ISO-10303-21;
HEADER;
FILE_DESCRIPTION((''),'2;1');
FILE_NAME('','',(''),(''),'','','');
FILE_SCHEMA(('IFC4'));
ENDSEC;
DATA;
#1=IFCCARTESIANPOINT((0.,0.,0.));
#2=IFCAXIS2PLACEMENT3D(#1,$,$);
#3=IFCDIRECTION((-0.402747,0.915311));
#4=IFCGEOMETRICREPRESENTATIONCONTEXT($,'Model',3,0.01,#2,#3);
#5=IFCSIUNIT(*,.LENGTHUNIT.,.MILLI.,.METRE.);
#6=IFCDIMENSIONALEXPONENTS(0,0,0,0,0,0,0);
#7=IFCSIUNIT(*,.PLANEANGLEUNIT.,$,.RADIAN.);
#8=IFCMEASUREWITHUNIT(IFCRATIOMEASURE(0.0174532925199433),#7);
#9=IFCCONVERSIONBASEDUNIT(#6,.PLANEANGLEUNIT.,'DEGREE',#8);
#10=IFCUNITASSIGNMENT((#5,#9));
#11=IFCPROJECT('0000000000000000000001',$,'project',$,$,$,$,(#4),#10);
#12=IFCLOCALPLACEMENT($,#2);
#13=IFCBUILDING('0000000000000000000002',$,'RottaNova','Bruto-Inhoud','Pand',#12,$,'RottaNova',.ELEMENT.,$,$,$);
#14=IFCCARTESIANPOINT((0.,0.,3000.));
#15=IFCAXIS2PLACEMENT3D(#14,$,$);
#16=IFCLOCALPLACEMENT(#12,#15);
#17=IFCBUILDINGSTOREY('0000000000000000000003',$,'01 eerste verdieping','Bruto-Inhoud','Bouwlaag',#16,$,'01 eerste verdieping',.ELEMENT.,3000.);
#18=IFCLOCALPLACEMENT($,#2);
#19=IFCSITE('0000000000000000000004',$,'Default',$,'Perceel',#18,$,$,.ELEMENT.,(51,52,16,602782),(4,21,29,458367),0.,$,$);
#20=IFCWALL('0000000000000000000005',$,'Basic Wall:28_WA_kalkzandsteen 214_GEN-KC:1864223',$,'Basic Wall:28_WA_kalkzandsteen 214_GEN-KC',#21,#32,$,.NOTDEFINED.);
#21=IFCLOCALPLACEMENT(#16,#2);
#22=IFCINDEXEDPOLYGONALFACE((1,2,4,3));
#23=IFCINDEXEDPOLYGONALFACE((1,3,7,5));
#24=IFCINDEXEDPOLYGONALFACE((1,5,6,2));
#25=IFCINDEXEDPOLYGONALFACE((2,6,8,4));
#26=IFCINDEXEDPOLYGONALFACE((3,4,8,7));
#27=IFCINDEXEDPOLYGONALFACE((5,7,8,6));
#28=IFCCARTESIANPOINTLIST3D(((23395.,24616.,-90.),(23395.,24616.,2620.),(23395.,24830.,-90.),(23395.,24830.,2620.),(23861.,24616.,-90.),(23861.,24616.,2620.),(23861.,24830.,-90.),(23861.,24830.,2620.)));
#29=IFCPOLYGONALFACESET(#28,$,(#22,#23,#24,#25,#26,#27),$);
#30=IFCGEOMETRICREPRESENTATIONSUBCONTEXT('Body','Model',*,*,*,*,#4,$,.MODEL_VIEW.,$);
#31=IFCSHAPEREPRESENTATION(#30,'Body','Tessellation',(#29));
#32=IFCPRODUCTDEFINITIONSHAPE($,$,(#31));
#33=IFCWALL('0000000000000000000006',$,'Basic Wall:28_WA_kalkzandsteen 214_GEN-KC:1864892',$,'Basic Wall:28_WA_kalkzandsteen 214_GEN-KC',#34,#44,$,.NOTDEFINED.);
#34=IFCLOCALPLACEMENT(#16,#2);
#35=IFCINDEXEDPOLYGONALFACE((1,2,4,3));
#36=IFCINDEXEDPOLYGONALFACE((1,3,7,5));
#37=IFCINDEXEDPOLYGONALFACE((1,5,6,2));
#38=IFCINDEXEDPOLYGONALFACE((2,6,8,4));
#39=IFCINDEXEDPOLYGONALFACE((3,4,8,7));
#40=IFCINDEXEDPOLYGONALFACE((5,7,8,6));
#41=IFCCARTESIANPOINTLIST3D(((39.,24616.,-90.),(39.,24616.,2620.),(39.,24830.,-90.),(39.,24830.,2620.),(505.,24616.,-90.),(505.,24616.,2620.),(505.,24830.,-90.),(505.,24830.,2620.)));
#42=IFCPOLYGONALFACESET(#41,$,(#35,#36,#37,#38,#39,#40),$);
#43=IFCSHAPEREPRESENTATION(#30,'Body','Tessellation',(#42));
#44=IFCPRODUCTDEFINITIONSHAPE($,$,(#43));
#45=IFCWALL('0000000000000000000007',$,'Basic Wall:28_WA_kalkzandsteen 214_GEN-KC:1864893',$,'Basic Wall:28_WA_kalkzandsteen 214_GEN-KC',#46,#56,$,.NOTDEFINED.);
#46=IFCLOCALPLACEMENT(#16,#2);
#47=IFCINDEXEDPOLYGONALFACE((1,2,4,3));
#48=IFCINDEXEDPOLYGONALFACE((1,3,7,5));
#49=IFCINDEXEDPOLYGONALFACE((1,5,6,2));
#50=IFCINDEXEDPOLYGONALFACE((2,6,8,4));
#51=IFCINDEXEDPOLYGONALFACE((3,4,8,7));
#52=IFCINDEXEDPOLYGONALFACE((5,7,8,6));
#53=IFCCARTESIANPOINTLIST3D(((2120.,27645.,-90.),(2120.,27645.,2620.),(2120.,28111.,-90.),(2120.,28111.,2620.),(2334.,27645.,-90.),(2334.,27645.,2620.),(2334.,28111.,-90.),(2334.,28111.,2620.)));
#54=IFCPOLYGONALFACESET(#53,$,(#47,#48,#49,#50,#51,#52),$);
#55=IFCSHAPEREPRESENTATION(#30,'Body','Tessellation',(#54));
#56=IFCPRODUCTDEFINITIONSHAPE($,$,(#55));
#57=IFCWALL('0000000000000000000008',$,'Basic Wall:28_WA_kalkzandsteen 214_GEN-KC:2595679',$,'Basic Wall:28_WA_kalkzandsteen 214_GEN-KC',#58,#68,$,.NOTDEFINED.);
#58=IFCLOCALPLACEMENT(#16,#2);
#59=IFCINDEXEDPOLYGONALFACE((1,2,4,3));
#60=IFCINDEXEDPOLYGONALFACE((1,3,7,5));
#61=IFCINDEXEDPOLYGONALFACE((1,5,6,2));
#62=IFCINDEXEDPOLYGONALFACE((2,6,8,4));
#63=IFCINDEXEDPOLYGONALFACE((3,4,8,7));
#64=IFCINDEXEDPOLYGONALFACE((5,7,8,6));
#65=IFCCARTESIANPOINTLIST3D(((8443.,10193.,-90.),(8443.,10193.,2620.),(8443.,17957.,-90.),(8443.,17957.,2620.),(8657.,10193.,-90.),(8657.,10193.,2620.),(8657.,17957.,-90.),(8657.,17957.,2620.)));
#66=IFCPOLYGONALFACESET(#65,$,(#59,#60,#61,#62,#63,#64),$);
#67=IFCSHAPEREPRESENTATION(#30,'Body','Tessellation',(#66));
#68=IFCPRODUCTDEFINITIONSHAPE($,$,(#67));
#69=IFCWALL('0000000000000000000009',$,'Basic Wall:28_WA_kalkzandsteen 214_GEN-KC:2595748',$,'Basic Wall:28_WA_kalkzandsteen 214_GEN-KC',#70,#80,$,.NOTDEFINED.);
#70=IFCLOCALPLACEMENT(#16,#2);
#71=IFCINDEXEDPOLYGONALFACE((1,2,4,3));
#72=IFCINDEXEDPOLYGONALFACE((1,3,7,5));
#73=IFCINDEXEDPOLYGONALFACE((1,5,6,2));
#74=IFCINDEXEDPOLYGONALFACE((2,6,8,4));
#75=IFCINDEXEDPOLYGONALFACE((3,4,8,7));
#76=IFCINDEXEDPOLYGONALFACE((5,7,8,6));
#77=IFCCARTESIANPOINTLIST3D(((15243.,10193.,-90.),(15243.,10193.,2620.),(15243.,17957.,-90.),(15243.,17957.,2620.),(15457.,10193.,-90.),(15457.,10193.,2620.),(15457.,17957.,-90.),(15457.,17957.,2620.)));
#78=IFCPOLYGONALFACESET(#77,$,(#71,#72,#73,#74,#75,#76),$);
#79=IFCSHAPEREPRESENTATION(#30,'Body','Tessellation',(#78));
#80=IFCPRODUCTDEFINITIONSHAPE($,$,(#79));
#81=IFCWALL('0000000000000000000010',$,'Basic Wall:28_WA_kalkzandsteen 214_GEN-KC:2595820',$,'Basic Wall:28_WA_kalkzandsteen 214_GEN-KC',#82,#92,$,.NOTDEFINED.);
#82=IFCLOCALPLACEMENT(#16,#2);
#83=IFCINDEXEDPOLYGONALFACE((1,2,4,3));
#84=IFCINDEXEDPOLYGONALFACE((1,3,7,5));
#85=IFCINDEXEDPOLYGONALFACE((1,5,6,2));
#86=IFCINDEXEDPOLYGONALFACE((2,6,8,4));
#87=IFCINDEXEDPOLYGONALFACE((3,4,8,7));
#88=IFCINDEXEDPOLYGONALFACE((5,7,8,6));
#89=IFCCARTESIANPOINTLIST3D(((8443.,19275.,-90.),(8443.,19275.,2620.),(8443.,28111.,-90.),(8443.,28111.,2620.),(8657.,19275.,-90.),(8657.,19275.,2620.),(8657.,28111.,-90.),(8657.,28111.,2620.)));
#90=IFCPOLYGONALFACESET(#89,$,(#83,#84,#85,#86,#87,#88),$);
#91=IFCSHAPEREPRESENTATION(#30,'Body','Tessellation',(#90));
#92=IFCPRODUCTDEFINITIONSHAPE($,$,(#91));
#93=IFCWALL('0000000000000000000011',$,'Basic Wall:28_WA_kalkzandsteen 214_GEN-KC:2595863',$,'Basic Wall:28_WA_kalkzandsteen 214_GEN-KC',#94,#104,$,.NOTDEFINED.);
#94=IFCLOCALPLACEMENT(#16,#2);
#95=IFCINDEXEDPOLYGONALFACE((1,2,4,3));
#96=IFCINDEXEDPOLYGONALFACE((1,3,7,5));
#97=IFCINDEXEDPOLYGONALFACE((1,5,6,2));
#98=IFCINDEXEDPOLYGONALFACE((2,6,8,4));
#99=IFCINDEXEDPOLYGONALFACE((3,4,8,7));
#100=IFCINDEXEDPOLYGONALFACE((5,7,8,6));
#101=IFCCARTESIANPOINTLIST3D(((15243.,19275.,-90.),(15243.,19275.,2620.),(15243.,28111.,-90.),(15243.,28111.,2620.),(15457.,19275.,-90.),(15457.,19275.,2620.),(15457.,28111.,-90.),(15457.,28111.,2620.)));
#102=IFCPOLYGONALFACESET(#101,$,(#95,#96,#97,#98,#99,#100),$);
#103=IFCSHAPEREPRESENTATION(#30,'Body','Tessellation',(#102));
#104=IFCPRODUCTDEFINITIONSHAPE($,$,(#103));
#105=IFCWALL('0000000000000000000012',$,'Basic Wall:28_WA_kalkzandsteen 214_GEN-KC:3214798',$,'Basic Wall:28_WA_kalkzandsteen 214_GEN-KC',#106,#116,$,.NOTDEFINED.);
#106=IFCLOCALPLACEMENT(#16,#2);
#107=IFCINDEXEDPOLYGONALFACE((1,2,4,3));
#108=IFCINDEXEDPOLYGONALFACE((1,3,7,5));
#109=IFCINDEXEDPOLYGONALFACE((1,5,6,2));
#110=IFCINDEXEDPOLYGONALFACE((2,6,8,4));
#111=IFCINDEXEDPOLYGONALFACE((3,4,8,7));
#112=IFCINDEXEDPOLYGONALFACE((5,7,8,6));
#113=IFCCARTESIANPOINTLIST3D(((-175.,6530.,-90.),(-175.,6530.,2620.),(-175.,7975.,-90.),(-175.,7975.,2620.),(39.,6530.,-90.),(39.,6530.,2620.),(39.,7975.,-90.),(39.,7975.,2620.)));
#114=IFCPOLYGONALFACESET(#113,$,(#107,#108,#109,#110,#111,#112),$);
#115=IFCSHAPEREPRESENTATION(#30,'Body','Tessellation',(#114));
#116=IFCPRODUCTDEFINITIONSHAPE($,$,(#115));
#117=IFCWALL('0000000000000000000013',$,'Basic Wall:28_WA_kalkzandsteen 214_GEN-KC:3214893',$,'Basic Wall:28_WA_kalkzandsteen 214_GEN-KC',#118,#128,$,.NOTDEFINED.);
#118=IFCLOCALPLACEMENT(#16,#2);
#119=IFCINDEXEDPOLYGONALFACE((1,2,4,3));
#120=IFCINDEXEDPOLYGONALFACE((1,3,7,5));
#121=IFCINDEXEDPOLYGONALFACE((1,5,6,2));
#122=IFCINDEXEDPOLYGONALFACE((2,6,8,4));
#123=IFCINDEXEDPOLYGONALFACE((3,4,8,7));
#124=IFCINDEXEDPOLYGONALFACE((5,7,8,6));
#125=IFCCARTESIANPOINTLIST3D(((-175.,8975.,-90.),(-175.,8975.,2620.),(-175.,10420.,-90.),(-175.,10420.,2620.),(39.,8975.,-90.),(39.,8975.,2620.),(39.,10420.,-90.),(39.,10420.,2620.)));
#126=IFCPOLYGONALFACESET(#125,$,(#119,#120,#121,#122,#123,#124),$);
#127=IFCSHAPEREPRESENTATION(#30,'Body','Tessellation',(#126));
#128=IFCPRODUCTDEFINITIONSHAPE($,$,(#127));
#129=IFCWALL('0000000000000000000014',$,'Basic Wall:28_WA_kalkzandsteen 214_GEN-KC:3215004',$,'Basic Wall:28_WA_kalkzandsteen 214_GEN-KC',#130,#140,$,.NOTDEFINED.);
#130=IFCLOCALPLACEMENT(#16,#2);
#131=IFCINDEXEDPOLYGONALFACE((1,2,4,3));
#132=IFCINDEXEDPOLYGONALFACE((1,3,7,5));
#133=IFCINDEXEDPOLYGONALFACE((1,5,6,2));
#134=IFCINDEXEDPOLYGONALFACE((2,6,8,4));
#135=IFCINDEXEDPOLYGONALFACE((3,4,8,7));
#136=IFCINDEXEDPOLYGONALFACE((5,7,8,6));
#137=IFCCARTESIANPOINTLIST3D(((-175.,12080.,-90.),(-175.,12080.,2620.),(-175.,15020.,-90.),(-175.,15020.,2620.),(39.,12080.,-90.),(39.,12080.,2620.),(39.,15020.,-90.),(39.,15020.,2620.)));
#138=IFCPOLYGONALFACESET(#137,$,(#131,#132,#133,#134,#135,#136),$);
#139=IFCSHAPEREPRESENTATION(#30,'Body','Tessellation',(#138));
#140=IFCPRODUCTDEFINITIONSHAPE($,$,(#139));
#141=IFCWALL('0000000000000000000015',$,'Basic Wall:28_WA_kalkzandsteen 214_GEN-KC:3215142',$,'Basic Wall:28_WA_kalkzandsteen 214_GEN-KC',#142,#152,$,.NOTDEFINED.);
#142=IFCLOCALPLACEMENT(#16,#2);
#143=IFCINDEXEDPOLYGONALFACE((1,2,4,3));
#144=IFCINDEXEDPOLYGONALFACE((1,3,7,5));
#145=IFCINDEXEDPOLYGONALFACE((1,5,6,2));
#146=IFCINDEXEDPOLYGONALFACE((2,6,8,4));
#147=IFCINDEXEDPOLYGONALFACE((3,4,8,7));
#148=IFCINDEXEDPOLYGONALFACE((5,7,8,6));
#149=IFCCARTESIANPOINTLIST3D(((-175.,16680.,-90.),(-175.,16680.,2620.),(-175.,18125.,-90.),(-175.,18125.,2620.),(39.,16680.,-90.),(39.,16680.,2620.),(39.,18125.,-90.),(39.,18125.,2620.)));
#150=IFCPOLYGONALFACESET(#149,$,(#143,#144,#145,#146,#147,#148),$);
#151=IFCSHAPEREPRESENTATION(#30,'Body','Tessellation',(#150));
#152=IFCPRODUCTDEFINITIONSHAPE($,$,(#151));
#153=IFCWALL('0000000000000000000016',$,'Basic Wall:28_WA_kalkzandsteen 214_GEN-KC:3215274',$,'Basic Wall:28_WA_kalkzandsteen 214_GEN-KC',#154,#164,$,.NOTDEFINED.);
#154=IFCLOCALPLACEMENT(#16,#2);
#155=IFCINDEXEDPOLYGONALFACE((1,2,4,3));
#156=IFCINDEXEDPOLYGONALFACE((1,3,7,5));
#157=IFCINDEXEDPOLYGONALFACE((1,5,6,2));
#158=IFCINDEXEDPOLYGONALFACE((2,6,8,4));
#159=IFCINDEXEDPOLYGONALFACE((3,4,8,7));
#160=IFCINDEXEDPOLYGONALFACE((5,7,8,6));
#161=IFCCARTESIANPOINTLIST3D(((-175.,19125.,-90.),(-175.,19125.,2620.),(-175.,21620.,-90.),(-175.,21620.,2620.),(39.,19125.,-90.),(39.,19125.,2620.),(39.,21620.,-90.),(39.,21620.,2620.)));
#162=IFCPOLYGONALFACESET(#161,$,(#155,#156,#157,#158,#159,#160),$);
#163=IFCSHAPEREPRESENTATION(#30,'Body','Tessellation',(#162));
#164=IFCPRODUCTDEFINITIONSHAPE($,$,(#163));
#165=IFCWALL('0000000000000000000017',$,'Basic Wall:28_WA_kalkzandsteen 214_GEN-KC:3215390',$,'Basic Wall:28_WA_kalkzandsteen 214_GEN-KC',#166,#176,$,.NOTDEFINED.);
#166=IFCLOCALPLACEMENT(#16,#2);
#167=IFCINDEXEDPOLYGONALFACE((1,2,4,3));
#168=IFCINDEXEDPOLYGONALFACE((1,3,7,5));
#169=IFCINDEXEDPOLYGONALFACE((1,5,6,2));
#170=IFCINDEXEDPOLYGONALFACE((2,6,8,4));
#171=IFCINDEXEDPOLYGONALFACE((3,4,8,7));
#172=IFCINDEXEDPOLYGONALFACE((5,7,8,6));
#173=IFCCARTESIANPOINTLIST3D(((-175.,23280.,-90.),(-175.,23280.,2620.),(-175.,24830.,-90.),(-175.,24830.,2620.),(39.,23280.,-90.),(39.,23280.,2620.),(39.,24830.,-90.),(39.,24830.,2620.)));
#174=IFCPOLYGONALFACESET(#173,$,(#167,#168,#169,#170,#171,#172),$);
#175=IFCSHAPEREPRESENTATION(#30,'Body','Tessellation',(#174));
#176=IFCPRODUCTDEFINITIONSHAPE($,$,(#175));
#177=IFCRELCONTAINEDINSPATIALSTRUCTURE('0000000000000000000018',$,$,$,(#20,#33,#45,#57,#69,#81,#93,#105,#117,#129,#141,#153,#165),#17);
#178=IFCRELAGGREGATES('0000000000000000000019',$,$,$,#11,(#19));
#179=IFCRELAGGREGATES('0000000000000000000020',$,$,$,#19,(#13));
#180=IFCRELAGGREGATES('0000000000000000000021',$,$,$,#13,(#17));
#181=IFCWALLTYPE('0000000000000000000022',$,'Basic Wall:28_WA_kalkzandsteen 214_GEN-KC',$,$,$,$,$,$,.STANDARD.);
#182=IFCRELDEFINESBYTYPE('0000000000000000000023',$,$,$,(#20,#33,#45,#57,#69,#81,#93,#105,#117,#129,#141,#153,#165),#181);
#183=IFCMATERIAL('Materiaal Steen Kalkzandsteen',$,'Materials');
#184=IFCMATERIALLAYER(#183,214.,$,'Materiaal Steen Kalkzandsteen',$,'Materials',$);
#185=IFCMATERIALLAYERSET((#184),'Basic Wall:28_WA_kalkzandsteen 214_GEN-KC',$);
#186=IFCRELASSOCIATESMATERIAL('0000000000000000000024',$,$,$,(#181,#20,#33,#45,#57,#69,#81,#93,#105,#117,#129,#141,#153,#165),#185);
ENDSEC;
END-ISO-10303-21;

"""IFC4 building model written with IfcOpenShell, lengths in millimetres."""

from ifc_helpers import new_model, entity, si_unit, converted_unit, direction, frame, frame_2d, origin, place, context, subcontext, project, spatial, rectangle, extrude, material, layer, layer_set, type_object, element, save


model = new_model("IFC4")

# Units and contexts
model_context = context("Model", 3, precision=0.01, world=origin(), true_north=direction((-0.402747, 0.915311)))
body_context = subcontext(model_context, "Body", "Model", "MODEL_VIEW")
ifc_project = project(units=[si_unit("LENGTHUNIT", "METRE", prefix="MILLI"), converted_unit("PLANEANGLEUNIT", "DEGREE", entity("IfcRatioMeasure", 0.0174532925199433), si_unit("PLANEANGLEUNIT", "RADIAN"), dimensions=[0, 0, 0, 0, 0, 0, 0])], contexts=[model_context])

# Site, building, storey
site_placement = place(None, origin())
site = spatial("IfcSite", under=ifc_project, at=site_placement, Name="Default", ObjectType="Perceel", CompositionType="ELEMENT", RefLatitude=(51, 52, 16, 602782), RefLongitude=(4, 21, 29, 458367), RefElevation=0.0)
building_placement = place(None, origin())
building = spatial("IfcBuilding", under=site, at=building_placement, Name="RottaNova", Description="Bruto-Inhoud", ObjectType="Pand", LongName="RottaNova", CompositionType="ELEMENT")
storey_placement = place(building_placement, frame((0.0, 0.0, 3000.0)))
storey = spatial("IfcBuildingStorey", under=building, at=storey_placement, Name="01 eerste verdieping", Description="Bruto-Inhoud", ObjectType="Bouwlaag", LongName="01 eerste verdieping", CompositionType="ELEMENT", Elevation=3000.0)

# Walls
ifc_material_1 = material(Name="Materiaal Steen Kalkzandsteen", Category="Materials")
ifc_layer_1 = layer(ifc_material_1, 214.0, Name="Materiaal Steen Kalkzandsteen", Category="Materials")
ifc_layer_set_1 = layer_set([ifc_layer_1], Name="Basic Wall:28_WA_kalkzandsteen 214_GEN-KC")
wall_type_1 = type_object("IfcWallType", Name="Basic Wall:28_WA_kalkzandsteen 214_GEN-KC", PredefinedType="STANDARD", material=ifc_layer_set_1)
wall_1_placement = place(storey_placement, frame((23395.0, 24723.0, -90.0)))
element("IfcWall", 1, at=wall_1_placement, inside=storey, type_object=wall_type_1, material=ifc_layer_set_1, Name="Basic Wall:28_WA_kalkzandsteen 214_GEN-KC:1864223", ObjectType="Basic Wall:28_WA_kalkzandsteen 214_GEN-KC", PredefinedType="NOTDEFINED", context=body_context, shape_type="SweptSolid", body=[
    extrude(rectangle(XDim=466.0, YDim=214.0, at=frame_2d((233.0, 0.0), x_axis=(-1.0, 0.0))), origin(), (0.0, 0.0, 1.0), 2710.0),
])
wall_2_placement = place(storey_placement, frame((39.0, 24723.0, -90.0)))
element("IfcWall", 2, at=wall_2_placement, inside=storey, type_object=wall_type_1, material=ifc_layer_set_1, Name="Basic Wall:28_WA_kalkzandsteen 214_GEN-KC:1864892", ObjectType="Basic Wall:28_WA_kalkzandsteen 214_GEN-KC", PredefinedType="NOTDEFINED", context=body_context, shape_type="SweptSolid", body=[
    extrude(rectangle(XDim=466.0, YDim=214.0, at=frame_2d((233.0, 0.0), x_axis=(-1.0, 0.0))), origin(), (0.0, 0.0, 1.0), 2710.0),
])
wall_3_placement = place(storey_placement, frame((2227.0, 28111.0, -90.0), z_axis=(0.0, 0.0, 1.0), x_axis=(0.0, -1.0, 0.0)))
element("IfcWall", 3, at=wall_3_placement, inside=storey, type_object=wall_type_1, material=ifc_layer_set_1, Name="Basic Wall:28_WA_kalkzandsteen 214_GEN-KC:1864893", ObjectType="Basic Wall:28_WA_kalkzandsteen 214_GEN-KC", PredefinedType="NOTDEFINED", context=body_context, shape_type="SweptSolid", body=[
    extrude(rectangle(XDim=466.0, YDim=214.0, at=frame_2d((233.0, 0.0), x_axis=(-1.0, 0.0))), origin(), (0.0, 0.0, 1.0), 2710.0),
])
wall_4_placement = place(storey_placement, frame((8550.0, 10193.0, -90.0), z_axis=(0.0, 0.0, 1.0), x_axis=(0.0, 1.0, 0.0)))
element("IfcWall", 4, at=wall_4_placement, inside=storey, type_object=wall_type_1, material=ifc_layer_set_1, Name="Basic Wall:28_WA_kalkzandsteen 214_GEN-KC:2595679", ObjectType="Basic Wall:28_WA_kalkzandsteen 214_GEN-KC", PredefinedType="NOTDEFINED", context=body_context, shape_type="SweptSolid", body=[
    extrude(rectangle(XDim=7764.0, YDim=214.0, at=frame_2d((3882.0, 0.0), x_axis=(1.0, 0.0))), origin(), (0.0, 0.0, 1.0), 2710.0),
])
wall_5_placement = place(storey_placement, frame((15350.0, 10193.0, -90.0), z_axis=(0.0, 0.0, 1.0), x_axis=(0.0, 1.0, 0.0)))
element("IfcWall", 5, at=wall_5_placement, inside=storey, type_object=wall_type_1, material=ifc_layer_set_1, Name="Basic Wall:28_WA_kalkzandsteen 214_GEN-KC:2595748", ObjectType="Basic Wall:28_WA_kalkzandsteen 214_GEN-KC", PredefinedType="NOTDEFINED", context=body_context, shape_type="SweptSolid", body=[
    extrude(rectangle(XDim=7764.0, YDim=214.0, at=frame_2d((3882.0, 0.0), x_axis=(1.0, 0.0))), origin(), (0.0, 0.0, 1.0), 2710.0),
])
wall_6_placement = place(storey_placement, frame((8550.0, 19275.0, -90.0), z_axis=(0.0, 0.0, 1.0), x_axis=(0.0, 1.0, 0.0)))
element("IfcWall", 6, at=wall_6_placement, inside=storey, type_object=wall_type_1, material=ifc_layer_set_1, Name="Basic Wall:28_WA_kalkzandsteen 214_GEN-KC:2595820", ObjectType="Basic Wall:28_WA_kalkzandsteen 214_GEN-KC", PredefinedType="NOTDEFINED", context=body_context, shape_type="SweptSolid", body=[
    extrude(rectangle(XDim=8836.0, YDim=214.0, at=frame_2d((0.0, 0.0), x_axis=(1.0, 0.0))), frame((4418.0, 0.0, 0.0), z_axis=(0.0, 0.0, 1.0), x_axis=(-1.0, 0.0, 0.0)), (0.0, 0.0, 1.0), 2710.0),
])
wall_7_placement = place(storey_placement, frame((15350.0, 19275.0, -90.0), z_axis=(0.0, 0.0, 1.0), x_axis=(0.0, 1.0, 0.0)))
element("IfcWall", 7, at=wall_7_placement, inside=storey, type_object=wall_type_1, material=ifc_layer_set_1, Name="Basic Wall:28_WA_kalkzandsteen 214_GEN-KC:2595863", ObjectType="Basic Wall:28_WA_kalkzandsteen 214_GEN-KC", PredefinedType="NOTDEFINED", context=body_context, shape_type="SweptSolid", body=[
    extrude(rectangle(XDim=8836.0, YDim=214.0, at=frame_2d((0.0, 0.0), x_axis=(1.0, 0.0))), frame((4418.0, 0.0, 0.0), z_axis=(0.0, 0.0, 1.0), x_axis=(-1.0, 0.0, 0.0)), (0.0, 0.0, 1.0), 2710.0),
])
wall_8_placement = place(storey_placement, frame((-68.0, 6530.0, -90.0), z_axis=(0.0, 0.0, 1.0), x_axis=(0.0, 1.0, 0.0)))
element("IfcWall", 8, at=wall_8_placement, inside=storey, type_object=wall_type_1, material=ifc_layer_set_1, Name="Basic Wall:28_WA_kalkzandsteen 214_GEN-KC:3214798", ObjectType="Basic Wall:28_WA_kalkzandsteen 214_GEN-KC", PredefinedType="NOTDEFINED", context=body_context, shape_type="SweptSolid", body=[
    extrude(rectangle(XDim=1445.0, YDim=214.0, at=frame_2d((722.5, 0.0), x_axis=(-1.0, 0.0))), origin(), (0.0, 0.0, 1.0), 2710.0),
])
wall_9_placement = place(storey_placement, frame((-68.0, 8975.0, -90.0), z_axis=(0.0, 0.0, 1.0), x_axis=(0.0, 1.0, 0.0)))
element("IfcWall", 9, at=wall_9_placement, inside=storey, type_object=wall_type_1, material=ifc_layer_set_1, Name="Basic Wall:28_WA_kalkzandsteen 214_GEN-KC:3214893", ObjectType="Basic Wall:28_WA_kalkzandsteen 214_GEN-KC", PredefinedType="NOTDEFINED", context=body_context, shape_type="SweptSolid", body=[
    extrude(rectangle(XDim=1445.0, YDim=214.0, at=frame_2d((722.5, 0.0), x_axis=(-1.0, 0.0))), origin(), (0.0, 0.0, 1.0), 2710.0),
])
wall_10_placement = place(storey_placement, frame((-68.0, 12080.0, -90.0), z_axis=(0.0, 0.0, 1.0), x_axis=(0.0, 1.0, 0.0)))
element("IfcWall", 10, at=wall_10_placement, inside=storey, type_object=wall_type_1, material=ifc_layer_set_1, Name="Basic Wall:28_WA_kalkzandsteen 214_GEN-KC:3215004", ObjectType="Basic Wall:28_WA_kalkzandsteen 214_GEN-KC", PredefinedType="NOTDEFINED", context=body_context, shape_type="SweptSolid", body=[
    extrude(rectangle(XDim=2940.0, YDim=214.0, at=frame_2d((1470.0, 0.0), x_axis=(-1.0, 0.0))), origin(), (0.0, 0.0, 1.0), 2710.0),
])
wall_11_placement = place(storey_placement, frame((-68.0, 16680.0, -90.0), z_axis=(0.0, 0.0, 1.0), x_axis=(0.0, 1.0, 0.0)))
element("IfcWall", 11, at=wall_11_placement, inside=storey, type_object=wall_type_1, material=ifc_layer_set_1, Name="Basic Wall:28_WA_kalkzandsteen 214_GEN-KC:3215142", ObjectType="Basic Wall:28_WA_kalkzandsteen 214_GEN-KC", PredefinedType="NOTDEFINED", context=body_context, shape_type="SweptSolid", body=[
    extrude(rectangle(XDim=1445.0, YDim=214.0, at=frame_2d((722.5, 0.0), x_axis=(-1.0, 0.0))), origin(), (0.0, 0.0, 1.0), 2710.0),
])
wall_12_placement = place(storey_placement, frame((-68.0, 19125.0, -90.0), z_axis=(0.0, 0.0, 1.0), x_axis=(0.0, 1.0, 0.0)))
element("IfcWall", 12, at=wall_12_placement, inside=storey, type_object=wall_type_1, material=ifc_layer_set_1, Name="Basic Wall:28_WA_kalkzandsteen 214_GEN-KC:3215274", ObjectType="Basic Wall:28_WA_kalkzandsteen 214_GEN-KC", PredefinedType="NOTDEFINED", context=body_context, shape_type="SweptSolid", body=[
    extrude(rectangle(XDim=2495.0, YDim=214.0, at=frame_2d((1247.5, 0.0), x_axis=(-1.0, 0.0))), origin(), (0.0, 0.0, 1.0), 2710.0),
])
wall_13_placement = place(storey_placement, frame((-68.0, 23280.0, -90.0), z_axis=(0.0, 0.0, 1.0), x_axis=(0.0, 1.0, 0.0)))
element("IfcWall", 13, at=wall_13_placement, inside=storey, type_object=wall_type_1, material=ifc_layer_set_1, Name="Basic Wall:28_WA_kalkzandsteen 214_GEN-KC:3215390", ObjectType="Basic Wall:28_WA_kalkzandsteen 214_GEN-KC", PredefinedType="NOTDEFINED", context=body_context, shape_type="SweptSolid", body=[
    extrude(rectangle(XDim=1550.0, YDim=214.0, at=frame_2d((775.0, 0.0), x_axis=(-1.0, 0.0))), origin(), (0.0, 0.0, 1.0), 2710.0),
])

save(model, "model.ifc")
